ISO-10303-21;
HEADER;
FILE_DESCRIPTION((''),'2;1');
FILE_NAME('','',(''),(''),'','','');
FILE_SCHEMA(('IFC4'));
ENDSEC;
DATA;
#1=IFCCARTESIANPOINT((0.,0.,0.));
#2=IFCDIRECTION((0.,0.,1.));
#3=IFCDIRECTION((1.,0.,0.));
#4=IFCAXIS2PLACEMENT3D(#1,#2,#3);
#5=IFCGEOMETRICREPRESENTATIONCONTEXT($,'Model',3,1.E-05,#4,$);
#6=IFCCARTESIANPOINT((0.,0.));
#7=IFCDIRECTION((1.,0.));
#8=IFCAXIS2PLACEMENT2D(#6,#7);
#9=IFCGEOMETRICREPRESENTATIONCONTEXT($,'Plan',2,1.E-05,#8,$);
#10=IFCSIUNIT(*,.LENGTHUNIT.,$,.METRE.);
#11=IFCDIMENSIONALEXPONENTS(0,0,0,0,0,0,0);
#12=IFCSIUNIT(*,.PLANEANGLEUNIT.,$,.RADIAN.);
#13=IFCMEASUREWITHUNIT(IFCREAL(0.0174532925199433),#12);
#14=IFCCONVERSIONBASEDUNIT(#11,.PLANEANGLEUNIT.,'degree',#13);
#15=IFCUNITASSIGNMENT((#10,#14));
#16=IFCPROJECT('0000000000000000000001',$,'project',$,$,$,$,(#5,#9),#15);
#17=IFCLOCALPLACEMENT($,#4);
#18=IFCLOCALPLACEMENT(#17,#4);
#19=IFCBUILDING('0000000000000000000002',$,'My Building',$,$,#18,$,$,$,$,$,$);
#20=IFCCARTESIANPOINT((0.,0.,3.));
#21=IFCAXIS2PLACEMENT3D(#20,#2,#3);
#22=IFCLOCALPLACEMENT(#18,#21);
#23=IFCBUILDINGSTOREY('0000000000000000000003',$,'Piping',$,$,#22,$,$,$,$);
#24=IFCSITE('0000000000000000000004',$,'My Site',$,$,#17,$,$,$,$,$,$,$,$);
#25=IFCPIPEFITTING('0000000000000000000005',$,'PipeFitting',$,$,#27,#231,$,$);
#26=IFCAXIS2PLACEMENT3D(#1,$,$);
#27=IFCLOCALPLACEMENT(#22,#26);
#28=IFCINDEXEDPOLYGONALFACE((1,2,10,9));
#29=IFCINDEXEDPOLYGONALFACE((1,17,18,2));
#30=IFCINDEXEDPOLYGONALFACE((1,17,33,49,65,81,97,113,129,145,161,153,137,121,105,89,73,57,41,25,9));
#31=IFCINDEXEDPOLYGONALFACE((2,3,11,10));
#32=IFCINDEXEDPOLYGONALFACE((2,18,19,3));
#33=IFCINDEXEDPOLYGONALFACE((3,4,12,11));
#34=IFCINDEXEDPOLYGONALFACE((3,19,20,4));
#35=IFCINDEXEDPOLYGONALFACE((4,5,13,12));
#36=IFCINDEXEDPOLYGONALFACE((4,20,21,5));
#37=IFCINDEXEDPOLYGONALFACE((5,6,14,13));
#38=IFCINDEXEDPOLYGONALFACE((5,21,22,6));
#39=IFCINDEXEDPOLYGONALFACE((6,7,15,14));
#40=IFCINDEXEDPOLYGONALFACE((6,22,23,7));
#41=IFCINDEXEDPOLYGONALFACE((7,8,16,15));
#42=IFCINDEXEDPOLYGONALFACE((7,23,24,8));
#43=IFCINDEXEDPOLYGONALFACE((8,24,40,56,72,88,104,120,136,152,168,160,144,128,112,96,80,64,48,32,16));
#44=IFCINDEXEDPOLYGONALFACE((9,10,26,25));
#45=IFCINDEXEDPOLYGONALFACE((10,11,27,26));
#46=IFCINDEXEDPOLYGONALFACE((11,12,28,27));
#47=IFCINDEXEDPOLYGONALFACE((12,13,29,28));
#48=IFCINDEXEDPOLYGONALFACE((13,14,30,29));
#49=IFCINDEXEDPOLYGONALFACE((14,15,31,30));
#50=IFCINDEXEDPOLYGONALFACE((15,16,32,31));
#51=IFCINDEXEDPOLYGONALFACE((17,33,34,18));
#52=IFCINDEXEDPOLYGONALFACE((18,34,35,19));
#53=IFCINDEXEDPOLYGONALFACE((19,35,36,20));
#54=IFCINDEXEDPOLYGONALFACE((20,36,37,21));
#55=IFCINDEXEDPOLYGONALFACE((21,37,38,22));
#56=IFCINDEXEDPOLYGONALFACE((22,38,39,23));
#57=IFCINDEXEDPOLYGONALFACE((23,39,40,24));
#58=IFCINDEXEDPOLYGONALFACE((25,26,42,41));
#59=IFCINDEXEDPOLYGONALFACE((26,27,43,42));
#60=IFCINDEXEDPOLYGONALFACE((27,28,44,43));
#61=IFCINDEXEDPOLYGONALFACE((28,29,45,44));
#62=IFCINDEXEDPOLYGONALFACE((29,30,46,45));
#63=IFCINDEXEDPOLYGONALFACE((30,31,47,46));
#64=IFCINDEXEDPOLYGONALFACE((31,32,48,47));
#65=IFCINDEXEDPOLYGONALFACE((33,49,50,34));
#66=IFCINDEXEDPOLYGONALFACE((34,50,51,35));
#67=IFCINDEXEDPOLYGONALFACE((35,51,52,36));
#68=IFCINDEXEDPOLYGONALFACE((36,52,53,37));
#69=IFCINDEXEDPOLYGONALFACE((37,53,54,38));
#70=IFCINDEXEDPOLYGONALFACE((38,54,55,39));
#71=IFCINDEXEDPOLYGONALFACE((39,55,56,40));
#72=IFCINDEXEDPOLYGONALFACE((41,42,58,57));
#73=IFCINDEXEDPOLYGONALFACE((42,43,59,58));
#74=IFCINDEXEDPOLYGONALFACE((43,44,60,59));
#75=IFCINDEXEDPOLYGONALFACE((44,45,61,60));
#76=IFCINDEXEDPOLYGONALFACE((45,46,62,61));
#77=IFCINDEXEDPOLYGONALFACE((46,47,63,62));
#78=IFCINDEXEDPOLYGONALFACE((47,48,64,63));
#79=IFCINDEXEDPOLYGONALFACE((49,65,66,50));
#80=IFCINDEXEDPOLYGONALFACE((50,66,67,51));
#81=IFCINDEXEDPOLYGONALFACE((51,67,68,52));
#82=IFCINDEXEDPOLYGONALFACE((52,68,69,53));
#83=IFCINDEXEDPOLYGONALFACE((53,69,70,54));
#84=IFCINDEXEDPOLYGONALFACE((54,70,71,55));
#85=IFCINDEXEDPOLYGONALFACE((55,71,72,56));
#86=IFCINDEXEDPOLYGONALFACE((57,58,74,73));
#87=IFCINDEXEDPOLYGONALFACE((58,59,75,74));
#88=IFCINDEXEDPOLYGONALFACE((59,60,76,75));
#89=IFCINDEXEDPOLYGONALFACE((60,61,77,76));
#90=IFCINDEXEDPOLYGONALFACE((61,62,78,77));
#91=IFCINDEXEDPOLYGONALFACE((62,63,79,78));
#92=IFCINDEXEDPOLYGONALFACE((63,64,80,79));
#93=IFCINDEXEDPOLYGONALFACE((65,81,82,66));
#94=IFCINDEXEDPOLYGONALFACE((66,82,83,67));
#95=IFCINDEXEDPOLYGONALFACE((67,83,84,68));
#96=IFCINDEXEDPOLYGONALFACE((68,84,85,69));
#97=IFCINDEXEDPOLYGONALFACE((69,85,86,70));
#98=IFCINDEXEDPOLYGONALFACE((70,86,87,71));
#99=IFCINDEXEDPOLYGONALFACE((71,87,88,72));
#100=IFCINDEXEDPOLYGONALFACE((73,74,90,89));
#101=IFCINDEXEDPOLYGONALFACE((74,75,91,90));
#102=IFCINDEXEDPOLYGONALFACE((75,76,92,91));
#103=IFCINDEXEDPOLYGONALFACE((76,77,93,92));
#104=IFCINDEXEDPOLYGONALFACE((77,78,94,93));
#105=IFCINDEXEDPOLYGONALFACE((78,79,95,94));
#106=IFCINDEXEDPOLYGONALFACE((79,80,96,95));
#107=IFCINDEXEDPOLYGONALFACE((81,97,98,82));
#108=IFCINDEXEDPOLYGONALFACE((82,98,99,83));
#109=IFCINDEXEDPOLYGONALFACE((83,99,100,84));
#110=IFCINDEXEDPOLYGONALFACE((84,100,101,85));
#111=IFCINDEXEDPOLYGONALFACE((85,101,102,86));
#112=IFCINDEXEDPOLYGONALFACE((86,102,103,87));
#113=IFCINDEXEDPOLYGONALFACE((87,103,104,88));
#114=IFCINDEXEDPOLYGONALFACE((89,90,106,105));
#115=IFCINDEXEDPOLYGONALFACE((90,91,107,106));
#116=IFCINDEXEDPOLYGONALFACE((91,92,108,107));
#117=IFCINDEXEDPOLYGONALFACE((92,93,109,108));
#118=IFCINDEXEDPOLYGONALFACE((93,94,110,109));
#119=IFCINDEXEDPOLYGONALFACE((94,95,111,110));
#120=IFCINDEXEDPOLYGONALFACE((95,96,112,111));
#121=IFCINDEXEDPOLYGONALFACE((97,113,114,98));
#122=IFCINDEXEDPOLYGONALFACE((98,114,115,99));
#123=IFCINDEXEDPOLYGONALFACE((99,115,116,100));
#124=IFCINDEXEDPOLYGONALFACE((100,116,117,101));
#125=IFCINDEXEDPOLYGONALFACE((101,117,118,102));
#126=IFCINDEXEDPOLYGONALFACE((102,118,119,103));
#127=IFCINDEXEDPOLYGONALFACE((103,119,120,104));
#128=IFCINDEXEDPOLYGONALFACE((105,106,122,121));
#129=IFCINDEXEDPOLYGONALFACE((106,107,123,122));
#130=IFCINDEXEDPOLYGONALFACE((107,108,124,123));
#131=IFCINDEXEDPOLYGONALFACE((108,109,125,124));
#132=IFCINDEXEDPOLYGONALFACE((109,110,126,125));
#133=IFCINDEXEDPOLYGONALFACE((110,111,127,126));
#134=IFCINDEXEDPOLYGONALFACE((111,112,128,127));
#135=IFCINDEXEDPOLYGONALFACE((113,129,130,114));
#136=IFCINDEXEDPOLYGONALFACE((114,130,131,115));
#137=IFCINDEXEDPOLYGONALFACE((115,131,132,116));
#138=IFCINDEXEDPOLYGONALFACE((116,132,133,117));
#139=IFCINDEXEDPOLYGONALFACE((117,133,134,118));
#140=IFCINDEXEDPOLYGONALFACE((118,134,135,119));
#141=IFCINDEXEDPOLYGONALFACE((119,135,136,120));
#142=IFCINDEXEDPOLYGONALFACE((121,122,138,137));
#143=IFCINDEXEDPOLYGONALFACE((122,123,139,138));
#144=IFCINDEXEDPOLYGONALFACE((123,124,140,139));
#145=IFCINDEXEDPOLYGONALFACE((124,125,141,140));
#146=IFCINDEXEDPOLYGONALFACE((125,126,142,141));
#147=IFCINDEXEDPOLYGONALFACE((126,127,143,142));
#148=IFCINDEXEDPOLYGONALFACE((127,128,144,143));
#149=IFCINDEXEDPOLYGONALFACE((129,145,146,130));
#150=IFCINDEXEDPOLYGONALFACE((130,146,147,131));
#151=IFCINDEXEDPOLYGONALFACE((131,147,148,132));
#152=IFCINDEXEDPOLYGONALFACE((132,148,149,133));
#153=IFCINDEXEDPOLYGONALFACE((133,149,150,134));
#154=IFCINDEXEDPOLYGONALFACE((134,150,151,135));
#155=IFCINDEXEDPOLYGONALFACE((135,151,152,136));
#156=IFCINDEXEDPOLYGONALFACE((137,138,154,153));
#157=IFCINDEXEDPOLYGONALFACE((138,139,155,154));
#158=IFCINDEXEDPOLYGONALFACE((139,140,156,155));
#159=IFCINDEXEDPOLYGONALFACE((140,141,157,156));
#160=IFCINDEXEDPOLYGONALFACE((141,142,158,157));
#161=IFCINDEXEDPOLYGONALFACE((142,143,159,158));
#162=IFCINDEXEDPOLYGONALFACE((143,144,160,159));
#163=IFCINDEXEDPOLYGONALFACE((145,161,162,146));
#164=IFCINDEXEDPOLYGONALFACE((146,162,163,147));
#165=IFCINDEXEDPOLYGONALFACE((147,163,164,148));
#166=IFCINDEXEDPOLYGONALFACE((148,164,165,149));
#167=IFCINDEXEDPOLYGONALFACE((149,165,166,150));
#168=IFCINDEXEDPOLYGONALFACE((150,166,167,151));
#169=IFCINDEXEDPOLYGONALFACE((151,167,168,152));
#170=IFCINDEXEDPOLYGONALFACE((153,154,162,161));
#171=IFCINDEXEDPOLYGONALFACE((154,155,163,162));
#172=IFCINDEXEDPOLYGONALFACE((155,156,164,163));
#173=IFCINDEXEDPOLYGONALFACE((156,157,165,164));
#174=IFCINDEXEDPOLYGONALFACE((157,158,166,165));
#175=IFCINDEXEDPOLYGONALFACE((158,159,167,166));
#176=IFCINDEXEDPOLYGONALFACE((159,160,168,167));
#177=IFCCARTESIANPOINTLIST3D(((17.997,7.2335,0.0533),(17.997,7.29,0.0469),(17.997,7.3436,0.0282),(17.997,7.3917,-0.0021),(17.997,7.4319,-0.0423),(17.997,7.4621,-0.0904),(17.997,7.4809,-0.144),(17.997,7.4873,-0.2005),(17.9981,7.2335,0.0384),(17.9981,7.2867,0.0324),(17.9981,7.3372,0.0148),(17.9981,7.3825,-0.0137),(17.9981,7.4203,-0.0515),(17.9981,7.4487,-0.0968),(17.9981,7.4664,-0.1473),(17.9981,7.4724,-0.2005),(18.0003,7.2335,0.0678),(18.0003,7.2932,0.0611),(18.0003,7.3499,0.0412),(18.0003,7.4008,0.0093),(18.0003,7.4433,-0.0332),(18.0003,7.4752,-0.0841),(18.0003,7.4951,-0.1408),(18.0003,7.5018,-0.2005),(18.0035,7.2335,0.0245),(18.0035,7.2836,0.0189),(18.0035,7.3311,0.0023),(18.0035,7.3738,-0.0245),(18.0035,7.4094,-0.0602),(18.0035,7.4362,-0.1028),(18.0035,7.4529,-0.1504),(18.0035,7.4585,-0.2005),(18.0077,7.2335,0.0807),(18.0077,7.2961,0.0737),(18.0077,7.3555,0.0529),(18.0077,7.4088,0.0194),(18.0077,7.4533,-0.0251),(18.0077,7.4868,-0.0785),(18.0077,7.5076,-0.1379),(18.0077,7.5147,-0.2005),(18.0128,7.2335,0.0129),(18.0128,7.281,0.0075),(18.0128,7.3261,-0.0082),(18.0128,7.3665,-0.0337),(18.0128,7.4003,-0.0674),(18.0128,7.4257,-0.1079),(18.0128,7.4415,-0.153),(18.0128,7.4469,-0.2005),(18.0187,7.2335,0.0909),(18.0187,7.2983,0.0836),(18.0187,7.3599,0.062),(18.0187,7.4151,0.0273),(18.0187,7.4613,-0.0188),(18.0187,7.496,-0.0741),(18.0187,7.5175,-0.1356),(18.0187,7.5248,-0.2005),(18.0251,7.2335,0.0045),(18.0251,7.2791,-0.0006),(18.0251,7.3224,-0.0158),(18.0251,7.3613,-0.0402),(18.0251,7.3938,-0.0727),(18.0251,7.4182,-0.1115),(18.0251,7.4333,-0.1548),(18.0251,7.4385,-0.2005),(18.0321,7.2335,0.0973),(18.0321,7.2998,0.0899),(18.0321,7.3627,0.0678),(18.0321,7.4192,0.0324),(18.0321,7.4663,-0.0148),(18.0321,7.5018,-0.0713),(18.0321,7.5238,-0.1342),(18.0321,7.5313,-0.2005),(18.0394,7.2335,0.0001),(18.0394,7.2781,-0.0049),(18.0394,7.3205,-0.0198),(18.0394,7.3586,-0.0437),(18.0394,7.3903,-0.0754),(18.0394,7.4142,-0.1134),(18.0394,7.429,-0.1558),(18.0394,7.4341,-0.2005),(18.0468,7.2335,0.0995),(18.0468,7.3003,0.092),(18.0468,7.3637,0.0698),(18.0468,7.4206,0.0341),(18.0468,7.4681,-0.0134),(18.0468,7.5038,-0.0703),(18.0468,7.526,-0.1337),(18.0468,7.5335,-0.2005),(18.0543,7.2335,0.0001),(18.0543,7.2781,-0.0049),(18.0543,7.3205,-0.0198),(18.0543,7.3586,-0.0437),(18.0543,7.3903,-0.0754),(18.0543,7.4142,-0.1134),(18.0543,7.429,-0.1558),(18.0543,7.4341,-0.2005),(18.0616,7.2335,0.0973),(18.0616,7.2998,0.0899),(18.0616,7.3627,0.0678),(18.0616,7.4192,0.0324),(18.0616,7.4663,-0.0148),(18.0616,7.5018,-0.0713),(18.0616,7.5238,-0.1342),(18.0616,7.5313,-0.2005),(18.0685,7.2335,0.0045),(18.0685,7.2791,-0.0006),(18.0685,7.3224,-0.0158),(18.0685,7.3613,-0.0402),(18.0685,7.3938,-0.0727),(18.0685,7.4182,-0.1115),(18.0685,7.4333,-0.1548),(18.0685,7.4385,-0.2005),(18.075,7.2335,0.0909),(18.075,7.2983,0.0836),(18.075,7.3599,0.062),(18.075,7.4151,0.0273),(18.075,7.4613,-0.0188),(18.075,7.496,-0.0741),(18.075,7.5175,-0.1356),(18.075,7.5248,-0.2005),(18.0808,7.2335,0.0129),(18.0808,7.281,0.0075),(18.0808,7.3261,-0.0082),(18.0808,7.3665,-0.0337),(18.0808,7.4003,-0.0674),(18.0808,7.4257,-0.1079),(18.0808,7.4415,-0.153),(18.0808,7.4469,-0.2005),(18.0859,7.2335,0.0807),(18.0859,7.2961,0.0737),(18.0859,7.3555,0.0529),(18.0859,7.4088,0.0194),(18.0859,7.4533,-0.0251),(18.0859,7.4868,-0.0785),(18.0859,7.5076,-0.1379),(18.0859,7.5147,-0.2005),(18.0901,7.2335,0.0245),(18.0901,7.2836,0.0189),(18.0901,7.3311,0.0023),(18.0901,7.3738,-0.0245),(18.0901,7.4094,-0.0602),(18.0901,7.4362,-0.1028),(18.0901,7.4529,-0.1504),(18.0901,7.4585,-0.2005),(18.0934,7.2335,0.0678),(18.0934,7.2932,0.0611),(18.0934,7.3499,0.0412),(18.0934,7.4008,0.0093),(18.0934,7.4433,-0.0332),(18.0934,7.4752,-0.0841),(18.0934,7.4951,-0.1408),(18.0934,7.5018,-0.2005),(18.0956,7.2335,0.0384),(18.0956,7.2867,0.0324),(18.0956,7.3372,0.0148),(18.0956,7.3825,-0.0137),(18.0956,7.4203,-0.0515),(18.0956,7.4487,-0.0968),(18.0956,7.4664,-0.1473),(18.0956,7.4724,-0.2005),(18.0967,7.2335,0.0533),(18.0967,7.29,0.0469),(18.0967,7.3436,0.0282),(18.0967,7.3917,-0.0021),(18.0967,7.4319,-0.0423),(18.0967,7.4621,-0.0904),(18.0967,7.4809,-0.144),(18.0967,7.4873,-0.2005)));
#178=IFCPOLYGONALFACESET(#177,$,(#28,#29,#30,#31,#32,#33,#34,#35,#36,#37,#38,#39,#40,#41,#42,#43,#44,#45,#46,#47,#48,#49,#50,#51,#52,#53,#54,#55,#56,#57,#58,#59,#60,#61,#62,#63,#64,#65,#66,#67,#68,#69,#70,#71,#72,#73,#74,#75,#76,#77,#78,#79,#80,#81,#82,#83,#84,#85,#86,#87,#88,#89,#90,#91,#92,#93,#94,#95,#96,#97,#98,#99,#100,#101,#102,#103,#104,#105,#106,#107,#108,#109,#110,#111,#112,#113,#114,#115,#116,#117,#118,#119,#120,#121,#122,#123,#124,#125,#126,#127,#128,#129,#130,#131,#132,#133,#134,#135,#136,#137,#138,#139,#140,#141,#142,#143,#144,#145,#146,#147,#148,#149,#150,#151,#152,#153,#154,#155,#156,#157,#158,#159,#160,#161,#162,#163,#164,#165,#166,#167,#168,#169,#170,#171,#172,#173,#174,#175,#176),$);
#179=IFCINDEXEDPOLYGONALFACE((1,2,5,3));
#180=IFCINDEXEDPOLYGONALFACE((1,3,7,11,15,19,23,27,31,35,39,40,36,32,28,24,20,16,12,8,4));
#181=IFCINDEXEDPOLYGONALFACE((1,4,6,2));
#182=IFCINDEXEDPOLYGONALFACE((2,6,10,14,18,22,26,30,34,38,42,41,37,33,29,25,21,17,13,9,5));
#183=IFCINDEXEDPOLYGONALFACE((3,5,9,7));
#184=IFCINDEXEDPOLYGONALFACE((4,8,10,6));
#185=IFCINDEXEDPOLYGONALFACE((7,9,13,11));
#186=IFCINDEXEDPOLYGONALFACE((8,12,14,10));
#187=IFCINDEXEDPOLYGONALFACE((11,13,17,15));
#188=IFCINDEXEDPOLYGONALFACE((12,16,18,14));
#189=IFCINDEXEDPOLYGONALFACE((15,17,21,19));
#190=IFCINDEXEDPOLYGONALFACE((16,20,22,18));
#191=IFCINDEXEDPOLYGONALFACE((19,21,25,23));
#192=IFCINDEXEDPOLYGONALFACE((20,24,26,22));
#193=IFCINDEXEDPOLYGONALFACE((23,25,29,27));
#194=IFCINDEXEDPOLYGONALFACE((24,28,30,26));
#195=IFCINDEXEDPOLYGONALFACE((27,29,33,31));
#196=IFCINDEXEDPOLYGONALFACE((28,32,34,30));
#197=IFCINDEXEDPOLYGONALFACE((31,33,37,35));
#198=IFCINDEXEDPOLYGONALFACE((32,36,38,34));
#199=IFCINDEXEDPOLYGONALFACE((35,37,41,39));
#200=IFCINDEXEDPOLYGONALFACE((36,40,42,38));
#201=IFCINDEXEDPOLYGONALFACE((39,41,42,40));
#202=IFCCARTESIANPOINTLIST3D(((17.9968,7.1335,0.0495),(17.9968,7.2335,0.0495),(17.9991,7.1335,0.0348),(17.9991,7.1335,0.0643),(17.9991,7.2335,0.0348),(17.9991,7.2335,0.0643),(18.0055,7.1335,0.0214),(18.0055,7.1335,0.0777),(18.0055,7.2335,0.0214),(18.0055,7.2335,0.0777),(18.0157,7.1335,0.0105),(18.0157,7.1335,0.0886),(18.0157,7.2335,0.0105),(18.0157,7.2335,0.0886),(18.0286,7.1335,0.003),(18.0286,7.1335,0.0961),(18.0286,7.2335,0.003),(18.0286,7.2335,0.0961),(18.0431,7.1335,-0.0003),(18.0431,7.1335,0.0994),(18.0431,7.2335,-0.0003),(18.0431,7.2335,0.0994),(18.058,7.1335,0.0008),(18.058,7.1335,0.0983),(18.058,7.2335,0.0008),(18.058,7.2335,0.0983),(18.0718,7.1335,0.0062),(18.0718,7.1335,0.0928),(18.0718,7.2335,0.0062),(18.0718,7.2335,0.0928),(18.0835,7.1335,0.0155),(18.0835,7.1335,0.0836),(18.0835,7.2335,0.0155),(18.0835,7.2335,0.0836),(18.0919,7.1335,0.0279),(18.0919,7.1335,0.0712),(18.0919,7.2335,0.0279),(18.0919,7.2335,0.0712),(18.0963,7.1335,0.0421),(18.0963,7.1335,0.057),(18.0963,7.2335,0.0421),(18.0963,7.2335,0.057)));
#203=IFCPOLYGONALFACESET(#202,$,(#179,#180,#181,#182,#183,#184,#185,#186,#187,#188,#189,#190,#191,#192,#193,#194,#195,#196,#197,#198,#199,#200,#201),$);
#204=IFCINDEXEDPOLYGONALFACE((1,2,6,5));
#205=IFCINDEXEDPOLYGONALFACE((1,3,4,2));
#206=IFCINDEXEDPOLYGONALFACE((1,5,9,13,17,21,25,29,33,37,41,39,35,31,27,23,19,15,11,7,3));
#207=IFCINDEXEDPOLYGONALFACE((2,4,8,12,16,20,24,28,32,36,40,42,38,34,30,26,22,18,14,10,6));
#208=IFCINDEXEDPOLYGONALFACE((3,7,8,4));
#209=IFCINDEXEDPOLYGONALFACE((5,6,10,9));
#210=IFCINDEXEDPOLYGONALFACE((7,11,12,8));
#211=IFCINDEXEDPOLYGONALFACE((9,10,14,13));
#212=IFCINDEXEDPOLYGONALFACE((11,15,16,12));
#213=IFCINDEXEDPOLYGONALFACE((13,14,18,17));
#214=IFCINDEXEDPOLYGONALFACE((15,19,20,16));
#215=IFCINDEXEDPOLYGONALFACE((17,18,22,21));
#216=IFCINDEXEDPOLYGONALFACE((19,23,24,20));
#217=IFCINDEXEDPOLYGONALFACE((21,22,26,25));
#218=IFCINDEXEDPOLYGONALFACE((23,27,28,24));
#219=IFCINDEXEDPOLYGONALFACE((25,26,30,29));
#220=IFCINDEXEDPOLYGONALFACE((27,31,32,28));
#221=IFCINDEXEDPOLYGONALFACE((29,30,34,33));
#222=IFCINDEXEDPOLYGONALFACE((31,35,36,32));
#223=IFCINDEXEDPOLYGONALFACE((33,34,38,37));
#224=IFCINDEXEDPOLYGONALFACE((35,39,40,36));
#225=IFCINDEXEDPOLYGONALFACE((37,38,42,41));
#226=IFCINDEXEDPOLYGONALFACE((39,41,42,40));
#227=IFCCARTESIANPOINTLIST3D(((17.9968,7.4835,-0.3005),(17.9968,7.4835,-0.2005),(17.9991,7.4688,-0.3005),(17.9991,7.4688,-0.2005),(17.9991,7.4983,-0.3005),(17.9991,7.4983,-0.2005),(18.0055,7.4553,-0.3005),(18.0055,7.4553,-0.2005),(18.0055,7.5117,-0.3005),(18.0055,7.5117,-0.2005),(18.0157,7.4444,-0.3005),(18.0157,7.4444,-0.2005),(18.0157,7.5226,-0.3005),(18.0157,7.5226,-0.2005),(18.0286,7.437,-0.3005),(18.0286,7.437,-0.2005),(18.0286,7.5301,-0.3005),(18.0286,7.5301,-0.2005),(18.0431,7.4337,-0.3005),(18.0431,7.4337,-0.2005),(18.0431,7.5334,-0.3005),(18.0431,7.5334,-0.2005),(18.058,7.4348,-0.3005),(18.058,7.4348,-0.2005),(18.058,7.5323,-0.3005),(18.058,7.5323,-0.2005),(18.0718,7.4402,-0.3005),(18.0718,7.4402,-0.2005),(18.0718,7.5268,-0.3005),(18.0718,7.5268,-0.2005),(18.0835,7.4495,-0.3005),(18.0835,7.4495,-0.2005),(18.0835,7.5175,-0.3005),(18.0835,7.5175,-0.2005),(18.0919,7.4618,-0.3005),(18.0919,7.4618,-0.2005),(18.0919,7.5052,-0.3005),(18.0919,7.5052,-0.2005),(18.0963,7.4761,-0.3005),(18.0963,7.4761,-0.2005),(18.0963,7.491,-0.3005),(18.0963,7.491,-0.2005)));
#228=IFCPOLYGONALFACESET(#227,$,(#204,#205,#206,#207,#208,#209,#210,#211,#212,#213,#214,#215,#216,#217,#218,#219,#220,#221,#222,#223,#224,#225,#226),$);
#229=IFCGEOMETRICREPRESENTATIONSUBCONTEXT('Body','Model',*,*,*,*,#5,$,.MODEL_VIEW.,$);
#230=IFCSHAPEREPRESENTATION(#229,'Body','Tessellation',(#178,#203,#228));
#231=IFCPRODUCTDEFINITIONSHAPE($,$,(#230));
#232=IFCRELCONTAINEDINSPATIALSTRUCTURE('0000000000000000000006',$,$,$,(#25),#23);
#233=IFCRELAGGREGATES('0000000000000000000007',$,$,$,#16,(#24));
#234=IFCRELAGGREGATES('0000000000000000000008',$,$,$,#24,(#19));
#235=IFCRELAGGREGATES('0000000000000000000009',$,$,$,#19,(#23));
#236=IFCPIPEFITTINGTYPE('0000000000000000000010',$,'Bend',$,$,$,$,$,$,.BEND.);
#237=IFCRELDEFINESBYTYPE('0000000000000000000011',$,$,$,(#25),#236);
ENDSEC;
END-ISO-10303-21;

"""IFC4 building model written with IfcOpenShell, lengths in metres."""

from ifc_helpers import new_model, entity, si_unit, converted_unit, frame, origin_with_axes, origin_2d_with_axis, place, context, subcontext, project, spatial, circle, extrude, source, transform, mapped, type_object, type_shapes, element, save


model = new_model("IFC4")

# Units and contexts
model_context = context("Model", 3, precision=1e-05, world=origin_with_axes())
plan_context = context("Plan", 2, precision=1e-05, world=origin_2d_with_axis())
body_context = subcontext(model_context, "Body", "Model", "MODEL_VIEW")
ifc_project = project(units=[si_unit("LENGTHUNIT", "METRE"), converted_unit("PLANEANGLEUNIT", "degree", entity("IfcReal", 0.0174532925199433), si_unit("PLANEANGLEUNIT", "RADIAN"), dimensions=[0, 0, 0, 0, 0, 0, 0])], contexts=[model_context, plan_context])

# Site, building, storey
site_placement = place(None, origin_with_axes())
site = spatial("IfcSite", under=ifc_project, at=site_placement, Name="My Site")
building_placement = place(site_placement, origin_with_axes())
building = spatial("IfcBuilding", under=site, at=building_placement, Name="My Building")
storey_placement = place(building_placement, frame((0.0, 0.0, 3.0), z_axis=(0.0, 0.0, 1.0), x_axis=(1.0, 0.0, 0.0)))
storey = spatial("IfcBuildingStorey", under=building, at=storey_placement, Name="Piping")

# Pipe fitting
pipe_fitting_type = type_object("IfcPipeFittingType", Name="Bend", PredefinedType="BEND")
shared_shape = source(origin_with_axes(), body_context, "Body", "SolidModel", [
    entity("IfcSweptDiskSolid", entity("IfcIndexedPolyCurve", entity("IfcCartesianPointList3D", [[0.0, 0.0, 0.1], [0.0, -0.0732, 0.2768], [0.0, -0.25, 0.35]]), [entity("IfcArcIndex", [1, 2, 3])]), 0.05),
    extrude(circle(Radius=0.05), origin_with_axes(), (0.0, 0.0, 1.0), 0.1),
    extrude(circle(Radius=0.05), frame((0.0, -0.25, 0.35), z_axis=(0.0, -1.0, 0.0), x_axis=(1.0, 0.0, 0.0)), (0.0, 0.0, 1.0), 0.1),
])
type_shapes(pipe_fitting_type, [shared_shape])
for number, where, z_axis, x_axis, name in (
    (1, (18.0468, 7.1335, 0.0495), (0.0, 1.0, 0.0), (-1.0, 0.0, 0.0), "PipeFitting"),
):
    element("IfcPipeFitting", number, at=place(storey_placement, frame(where, z_axis=z_axis, x_axis=x_axis)), inside=storey, type_object=pipe_fitting_type, Name=name, context=body_context, shape_type="MappedRepresentation", body=[
        mapped(shared_shape, transform((0.0, 0.0, 0.0), x_axis=(1.0, 0.0, 0.0), y_axis=(0.0, 1.0, 0.0), z_axis=(0.0, 0.0, 1.0), scale=1.0)),
    ])

save(model, "model.ifc")
